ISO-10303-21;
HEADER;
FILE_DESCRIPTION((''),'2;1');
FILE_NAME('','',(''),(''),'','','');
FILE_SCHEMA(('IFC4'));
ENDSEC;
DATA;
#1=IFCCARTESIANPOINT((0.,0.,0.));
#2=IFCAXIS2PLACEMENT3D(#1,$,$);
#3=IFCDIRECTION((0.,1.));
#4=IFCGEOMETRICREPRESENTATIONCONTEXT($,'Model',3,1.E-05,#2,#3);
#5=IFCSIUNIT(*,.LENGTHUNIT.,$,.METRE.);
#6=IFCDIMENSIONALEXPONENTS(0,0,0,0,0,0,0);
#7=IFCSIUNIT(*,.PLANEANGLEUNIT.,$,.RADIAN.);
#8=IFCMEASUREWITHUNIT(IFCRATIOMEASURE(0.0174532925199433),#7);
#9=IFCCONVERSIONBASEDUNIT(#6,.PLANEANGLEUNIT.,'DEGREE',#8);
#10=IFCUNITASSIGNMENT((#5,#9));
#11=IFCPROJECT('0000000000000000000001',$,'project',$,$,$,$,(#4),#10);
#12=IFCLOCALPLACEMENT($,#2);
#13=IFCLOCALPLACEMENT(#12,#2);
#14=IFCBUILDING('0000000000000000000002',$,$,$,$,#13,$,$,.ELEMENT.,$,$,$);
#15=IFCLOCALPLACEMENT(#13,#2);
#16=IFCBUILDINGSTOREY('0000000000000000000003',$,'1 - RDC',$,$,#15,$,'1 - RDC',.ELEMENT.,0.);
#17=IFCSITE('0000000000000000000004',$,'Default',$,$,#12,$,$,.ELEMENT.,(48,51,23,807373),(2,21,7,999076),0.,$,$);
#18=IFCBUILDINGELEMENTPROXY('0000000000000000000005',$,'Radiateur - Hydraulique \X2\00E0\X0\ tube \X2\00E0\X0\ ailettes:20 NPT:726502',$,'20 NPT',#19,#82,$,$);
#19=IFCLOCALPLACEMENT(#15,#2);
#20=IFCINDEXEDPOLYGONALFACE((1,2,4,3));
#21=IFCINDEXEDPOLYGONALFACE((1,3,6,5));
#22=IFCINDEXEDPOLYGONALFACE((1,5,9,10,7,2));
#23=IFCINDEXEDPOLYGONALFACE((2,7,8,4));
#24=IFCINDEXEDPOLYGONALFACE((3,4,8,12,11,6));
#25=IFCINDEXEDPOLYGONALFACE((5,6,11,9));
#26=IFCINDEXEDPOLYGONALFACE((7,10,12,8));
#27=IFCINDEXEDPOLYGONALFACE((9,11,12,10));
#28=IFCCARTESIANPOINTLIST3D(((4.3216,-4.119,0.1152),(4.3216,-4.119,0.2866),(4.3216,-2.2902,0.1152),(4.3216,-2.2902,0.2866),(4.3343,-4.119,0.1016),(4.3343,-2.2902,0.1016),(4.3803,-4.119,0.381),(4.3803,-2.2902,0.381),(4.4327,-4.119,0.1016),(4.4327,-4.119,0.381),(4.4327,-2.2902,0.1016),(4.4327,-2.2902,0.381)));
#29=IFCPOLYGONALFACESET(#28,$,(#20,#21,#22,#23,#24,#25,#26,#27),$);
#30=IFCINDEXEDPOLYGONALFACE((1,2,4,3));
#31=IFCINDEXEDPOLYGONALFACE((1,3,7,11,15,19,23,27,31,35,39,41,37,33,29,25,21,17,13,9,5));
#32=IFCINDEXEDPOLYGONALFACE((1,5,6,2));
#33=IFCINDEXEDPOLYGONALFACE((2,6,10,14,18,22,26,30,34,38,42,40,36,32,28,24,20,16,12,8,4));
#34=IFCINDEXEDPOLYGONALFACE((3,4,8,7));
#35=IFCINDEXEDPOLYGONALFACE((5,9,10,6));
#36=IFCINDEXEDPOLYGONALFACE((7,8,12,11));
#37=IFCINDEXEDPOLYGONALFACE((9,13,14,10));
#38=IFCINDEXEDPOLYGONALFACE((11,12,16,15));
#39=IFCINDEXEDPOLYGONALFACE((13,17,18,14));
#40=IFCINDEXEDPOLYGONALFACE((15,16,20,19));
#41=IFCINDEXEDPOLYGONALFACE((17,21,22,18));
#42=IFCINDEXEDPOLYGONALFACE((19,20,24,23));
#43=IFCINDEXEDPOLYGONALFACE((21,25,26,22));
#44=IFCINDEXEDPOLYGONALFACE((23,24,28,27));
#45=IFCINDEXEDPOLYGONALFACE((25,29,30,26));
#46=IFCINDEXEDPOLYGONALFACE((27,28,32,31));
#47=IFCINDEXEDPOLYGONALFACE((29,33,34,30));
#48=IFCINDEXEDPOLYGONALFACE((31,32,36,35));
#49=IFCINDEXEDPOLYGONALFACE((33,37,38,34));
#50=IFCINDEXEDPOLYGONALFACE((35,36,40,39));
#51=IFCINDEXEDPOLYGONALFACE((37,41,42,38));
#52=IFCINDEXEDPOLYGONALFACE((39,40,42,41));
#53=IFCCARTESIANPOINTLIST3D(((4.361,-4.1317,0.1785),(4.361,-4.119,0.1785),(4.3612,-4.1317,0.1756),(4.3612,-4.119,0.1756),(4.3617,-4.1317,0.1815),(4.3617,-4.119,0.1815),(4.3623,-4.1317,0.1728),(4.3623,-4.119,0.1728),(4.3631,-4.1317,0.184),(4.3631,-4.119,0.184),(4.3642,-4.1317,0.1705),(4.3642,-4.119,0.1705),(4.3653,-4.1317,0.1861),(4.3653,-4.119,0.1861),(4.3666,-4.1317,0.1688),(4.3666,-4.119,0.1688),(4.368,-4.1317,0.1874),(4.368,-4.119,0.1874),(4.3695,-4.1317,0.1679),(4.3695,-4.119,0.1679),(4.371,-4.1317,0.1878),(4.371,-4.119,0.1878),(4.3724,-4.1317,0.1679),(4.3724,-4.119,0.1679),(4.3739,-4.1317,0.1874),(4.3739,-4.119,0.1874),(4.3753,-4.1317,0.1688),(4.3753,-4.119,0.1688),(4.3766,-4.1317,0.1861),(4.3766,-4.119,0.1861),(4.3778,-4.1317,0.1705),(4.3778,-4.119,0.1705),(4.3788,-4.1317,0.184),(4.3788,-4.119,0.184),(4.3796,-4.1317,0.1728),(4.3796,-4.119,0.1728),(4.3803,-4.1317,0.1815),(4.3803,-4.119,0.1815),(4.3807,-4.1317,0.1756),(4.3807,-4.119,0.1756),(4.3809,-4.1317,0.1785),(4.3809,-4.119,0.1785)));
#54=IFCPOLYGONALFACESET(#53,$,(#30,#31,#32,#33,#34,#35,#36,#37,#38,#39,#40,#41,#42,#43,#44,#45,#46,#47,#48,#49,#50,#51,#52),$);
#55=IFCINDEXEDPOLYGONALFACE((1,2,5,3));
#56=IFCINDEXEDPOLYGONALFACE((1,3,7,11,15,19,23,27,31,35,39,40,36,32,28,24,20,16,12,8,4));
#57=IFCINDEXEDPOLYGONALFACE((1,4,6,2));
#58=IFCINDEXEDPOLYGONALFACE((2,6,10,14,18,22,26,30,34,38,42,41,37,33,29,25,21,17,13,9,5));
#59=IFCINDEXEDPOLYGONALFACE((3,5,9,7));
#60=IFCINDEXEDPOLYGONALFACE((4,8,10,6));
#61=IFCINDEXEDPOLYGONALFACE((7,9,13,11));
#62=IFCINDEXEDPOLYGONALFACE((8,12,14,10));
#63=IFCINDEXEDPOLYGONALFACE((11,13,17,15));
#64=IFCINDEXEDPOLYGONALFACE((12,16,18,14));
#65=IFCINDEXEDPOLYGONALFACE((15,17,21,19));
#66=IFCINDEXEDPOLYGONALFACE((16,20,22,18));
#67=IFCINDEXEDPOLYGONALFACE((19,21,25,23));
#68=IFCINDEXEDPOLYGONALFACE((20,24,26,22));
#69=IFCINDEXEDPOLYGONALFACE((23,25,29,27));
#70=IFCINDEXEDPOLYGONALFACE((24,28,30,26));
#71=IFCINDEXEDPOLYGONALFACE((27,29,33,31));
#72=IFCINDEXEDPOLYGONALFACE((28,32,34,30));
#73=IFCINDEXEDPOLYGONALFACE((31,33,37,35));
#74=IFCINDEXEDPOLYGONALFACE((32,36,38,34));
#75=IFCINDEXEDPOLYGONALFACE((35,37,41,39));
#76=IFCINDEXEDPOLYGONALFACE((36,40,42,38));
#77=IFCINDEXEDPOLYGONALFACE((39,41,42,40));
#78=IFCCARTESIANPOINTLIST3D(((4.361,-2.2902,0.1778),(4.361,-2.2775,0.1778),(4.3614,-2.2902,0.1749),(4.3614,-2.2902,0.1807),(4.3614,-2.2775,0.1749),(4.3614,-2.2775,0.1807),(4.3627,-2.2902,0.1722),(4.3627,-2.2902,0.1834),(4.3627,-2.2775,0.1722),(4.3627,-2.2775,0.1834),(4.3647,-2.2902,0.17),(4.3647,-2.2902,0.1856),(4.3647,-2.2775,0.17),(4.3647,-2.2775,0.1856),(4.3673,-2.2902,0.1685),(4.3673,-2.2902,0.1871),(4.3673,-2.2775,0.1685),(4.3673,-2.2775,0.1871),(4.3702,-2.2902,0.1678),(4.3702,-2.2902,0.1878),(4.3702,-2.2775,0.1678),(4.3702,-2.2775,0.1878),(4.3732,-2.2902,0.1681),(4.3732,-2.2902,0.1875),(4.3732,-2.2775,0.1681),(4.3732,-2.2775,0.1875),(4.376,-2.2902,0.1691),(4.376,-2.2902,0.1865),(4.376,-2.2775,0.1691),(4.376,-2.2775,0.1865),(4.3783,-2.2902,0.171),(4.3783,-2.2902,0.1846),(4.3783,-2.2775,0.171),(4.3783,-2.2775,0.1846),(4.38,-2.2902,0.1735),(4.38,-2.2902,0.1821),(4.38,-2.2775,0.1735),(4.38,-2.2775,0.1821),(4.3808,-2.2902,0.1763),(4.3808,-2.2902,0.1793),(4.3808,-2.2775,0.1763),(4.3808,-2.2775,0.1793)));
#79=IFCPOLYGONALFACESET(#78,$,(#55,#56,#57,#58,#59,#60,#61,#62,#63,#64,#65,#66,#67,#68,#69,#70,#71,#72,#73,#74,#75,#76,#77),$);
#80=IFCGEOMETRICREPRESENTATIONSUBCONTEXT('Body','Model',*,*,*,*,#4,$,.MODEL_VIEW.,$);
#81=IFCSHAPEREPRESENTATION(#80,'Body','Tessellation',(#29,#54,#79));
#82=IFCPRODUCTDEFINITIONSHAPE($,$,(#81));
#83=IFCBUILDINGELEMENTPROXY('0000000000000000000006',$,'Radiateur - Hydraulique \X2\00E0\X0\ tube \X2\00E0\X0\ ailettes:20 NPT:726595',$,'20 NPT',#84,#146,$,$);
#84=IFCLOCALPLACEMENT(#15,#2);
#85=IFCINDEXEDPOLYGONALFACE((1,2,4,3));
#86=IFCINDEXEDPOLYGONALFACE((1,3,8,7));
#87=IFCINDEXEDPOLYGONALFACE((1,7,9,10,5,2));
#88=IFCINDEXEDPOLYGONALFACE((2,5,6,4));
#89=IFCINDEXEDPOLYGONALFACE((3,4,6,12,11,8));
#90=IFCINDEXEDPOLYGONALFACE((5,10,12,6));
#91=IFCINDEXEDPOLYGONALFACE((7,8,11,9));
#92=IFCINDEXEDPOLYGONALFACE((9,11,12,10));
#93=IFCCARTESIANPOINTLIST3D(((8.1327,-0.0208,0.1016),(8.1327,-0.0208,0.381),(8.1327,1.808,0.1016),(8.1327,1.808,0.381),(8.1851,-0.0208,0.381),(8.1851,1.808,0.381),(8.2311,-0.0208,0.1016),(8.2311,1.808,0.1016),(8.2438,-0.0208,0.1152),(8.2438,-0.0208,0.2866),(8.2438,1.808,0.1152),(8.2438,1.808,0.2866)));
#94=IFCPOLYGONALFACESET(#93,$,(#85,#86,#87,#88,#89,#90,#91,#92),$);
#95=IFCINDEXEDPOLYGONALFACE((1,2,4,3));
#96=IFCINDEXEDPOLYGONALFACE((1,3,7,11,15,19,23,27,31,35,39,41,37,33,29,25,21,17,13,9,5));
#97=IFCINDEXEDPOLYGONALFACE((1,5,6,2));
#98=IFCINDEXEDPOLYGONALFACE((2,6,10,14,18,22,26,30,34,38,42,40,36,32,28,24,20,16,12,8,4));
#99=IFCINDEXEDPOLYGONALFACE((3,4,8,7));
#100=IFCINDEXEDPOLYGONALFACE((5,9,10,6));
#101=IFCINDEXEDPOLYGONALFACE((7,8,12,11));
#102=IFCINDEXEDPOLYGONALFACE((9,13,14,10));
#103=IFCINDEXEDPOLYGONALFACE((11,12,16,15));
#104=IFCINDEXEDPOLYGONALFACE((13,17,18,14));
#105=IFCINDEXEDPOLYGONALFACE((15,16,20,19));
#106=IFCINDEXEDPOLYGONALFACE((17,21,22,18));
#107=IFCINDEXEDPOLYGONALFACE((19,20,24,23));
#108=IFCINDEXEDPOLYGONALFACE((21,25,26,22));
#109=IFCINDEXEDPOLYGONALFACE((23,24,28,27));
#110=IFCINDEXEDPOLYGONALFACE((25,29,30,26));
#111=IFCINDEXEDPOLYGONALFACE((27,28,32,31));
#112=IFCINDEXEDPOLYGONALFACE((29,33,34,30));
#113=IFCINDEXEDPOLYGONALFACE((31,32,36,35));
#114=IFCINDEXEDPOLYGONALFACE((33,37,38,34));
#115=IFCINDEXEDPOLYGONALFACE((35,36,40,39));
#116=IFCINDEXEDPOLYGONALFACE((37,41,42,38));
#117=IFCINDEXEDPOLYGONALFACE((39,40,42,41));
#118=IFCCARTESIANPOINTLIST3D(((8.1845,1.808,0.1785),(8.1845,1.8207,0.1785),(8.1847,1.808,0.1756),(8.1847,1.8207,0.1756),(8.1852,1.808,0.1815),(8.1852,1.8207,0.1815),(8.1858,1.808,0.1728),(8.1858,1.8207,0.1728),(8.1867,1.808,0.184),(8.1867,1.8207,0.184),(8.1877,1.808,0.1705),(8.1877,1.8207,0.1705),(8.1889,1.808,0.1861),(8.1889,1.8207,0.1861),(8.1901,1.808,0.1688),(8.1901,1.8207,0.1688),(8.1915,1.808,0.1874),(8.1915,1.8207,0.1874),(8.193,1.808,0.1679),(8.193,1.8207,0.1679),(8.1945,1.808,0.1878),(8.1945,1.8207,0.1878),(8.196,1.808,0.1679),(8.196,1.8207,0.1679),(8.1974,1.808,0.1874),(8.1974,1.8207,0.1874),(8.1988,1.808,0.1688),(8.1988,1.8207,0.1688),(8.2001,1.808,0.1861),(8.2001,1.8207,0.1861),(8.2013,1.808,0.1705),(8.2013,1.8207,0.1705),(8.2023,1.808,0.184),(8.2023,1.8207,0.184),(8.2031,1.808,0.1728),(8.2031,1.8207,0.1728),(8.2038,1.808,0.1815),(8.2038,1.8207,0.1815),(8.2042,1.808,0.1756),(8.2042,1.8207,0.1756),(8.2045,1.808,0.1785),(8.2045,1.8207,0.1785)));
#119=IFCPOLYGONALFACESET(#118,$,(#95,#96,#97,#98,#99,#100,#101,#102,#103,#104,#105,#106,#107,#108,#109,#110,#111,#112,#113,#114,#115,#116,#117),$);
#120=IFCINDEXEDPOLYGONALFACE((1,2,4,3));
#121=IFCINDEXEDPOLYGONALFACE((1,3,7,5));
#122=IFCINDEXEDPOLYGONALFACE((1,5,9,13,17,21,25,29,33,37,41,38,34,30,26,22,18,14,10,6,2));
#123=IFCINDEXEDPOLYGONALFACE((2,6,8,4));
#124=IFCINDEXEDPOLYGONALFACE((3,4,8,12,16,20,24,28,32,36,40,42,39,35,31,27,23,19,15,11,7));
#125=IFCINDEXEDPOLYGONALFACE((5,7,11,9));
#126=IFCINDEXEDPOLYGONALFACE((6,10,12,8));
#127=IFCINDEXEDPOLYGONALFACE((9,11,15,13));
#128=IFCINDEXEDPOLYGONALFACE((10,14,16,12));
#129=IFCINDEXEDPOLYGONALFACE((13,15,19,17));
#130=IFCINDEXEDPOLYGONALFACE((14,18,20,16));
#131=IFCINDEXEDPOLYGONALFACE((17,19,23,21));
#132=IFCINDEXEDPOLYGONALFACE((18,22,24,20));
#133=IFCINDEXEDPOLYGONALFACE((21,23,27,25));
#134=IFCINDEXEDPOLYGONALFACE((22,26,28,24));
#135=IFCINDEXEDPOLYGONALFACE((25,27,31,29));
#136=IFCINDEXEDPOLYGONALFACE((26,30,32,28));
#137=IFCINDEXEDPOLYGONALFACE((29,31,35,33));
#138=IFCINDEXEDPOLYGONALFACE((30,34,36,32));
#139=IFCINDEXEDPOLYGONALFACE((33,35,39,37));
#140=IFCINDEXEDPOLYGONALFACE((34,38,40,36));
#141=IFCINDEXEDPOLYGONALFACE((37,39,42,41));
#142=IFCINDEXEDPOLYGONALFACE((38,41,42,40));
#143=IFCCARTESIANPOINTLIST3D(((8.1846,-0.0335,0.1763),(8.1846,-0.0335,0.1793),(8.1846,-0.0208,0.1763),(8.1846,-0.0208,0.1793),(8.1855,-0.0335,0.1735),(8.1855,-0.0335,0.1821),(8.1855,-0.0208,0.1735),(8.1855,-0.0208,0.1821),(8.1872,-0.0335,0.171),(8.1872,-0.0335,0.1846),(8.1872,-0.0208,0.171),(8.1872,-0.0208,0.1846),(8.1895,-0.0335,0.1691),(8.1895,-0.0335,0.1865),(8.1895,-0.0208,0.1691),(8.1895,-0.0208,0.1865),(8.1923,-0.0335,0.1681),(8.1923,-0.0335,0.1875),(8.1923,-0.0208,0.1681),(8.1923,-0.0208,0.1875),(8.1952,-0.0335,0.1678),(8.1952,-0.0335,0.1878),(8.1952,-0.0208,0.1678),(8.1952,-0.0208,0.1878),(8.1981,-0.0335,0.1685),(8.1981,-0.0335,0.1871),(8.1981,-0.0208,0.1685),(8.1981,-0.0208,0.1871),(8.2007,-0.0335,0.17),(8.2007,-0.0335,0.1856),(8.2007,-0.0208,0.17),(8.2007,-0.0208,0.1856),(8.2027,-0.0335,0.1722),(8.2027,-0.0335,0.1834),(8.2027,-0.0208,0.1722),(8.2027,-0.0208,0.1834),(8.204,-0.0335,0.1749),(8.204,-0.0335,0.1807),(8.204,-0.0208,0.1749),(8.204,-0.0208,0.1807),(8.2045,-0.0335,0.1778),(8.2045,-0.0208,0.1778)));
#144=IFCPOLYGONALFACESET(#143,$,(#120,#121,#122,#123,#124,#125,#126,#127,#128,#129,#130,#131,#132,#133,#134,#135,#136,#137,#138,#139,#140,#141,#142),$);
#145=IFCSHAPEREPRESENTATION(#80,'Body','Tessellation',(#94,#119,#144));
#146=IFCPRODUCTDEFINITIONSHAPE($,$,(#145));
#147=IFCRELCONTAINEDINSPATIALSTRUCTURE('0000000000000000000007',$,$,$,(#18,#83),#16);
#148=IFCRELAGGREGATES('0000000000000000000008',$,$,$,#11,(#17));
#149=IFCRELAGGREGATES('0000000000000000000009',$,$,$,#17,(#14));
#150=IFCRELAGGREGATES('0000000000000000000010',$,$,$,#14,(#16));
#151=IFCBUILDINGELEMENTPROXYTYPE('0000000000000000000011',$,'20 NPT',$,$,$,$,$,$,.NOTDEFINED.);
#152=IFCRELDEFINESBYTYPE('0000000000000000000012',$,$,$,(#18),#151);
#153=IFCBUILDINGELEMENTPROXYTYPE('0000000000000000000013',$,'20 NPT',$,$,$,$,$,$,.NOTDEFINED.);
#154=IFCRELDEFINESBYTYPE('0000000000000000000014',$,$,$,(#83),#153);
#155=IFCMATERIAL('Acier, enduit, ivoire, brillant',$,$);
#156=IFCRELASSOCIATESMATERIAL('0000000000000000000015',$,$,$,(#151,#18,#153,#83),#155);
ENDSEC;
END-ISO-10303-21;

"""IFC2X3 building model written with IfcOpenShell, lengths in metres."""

from ifc_helpers import new_model, entity, si_unit, converted_unit, direction, frame, frame_2d, origin, place, context, subcontext, project, spatial, polyline, circle, outline, extrude, source, transform, mapped, material, type_object, type_shapes, element, save


model = new_model("IFC2X3")

# Units and contexts
model_context = context("Model", 3, precision=1e-05, world=origin(), true_north=direction((0.0, 1.0)))
body_context = subcontext(model_context, "Body", "Model", "MODEL_VIEW")
ifc_project = project(units=[si_unit("LENGTHUNIT", "METRE"), converted_unit("PLANEANGLEUNIT", "DEGREE", entity("IfcRatioMeasure", 0.0174532925199433), si_unit("PLANEANGLEUNIT", "RADIAN"), dimensions=[0, 0, 0, 0, 0, 0, 0])], contexts=[model_context])

# Site, building, storey
site_placement = place(None, origin())
site = spatial("IfcSite", under=ifc_project, at=site_placement, Name="Default", CompositionType="ELEMENT", RefLatitude=(48, 51, 23, 807373), RefLongitude=(2, 21, 7, 999076), RefElevation=0.0)
building_placement = place(site_placement, origin())
building = spatial("IfcBuilding", under=site, at=building_placement, CompositionType="ELEMENT")
storey_placement = place(building_placement, origin())
storey = spatial("IfcBuildingStorey", under=building, at=storey_placement, Name="1 - RDC", LongName="1 - RDC", CompositionType="ELEMENT", Elevation=0.0)

# Building element proxies
ifc_material = material(Name="Acier, enduit, ivoire, brillant")
building_element_proxy_type_1 = type_object("IfcBuildingElementProxyType", Name="20 NPT", PredefinedType="NOTDEFINED", material=ifc_material)
shared_shape_1 = source(origin(), body_context, "Body", "SweptSolid", [
    extrude(outline(polyline([(-0.0674, -0.1127), (-0.0488, -0.1127), (0.0764, 0.0044), (0.1052, 0.1118), (0.0694, 0.15), (-0.1347, -0.0408), (-0.0674, -0.1127)])), frame((-0.9144, 0.1322, 0.2278), z_axis=(1.0, 0.0, 0.0), x_axis=(0.0, 0.683102, 0.730323)), (0.0, 0.0, 1.0), 1.8288),
    extrude(circle(Radius=0.01, at=frame_2d((0.0, 0.0), x_axis=(1.0, 0.0))), frame((-0.9271, 0.1318, 0.1778), z_axis=(1.0, 0.0, 0.0), x_axis=(0.0, 0.0, 1.0)), (0.0, 0.0, 1.0), 0.0127),
    extrude(circle(Radius=0.01, at=frame_2d((0.0, 0.0), x_axis=(1.0, 0.0))), frame((0.9144, 0.1318, 0.1778), z_axis=(1.0, 0.0, 0.0), x_axis=(0.0, 1.0, 0.0)), (0.0, 0.0, 1.0), 0.0127),
])
type_shapes(building_element_proxy_type_1, [shared_shape_1])
proxy_1_placement = place(storey_placement, frame((4.5027, -3.2046, 0.0), z_axis=(0.0, 0.0, 1.0), x_axis=(0.0, 1.0, 0.0)))
element("IfcBuildingElementProxy", 1, at=proxy_1_placement, inside=storey, type_object=building_element_proxy_type_1, material=ifc_material, Name="Radiateur - Hydraulique à tube à ailettes:20 NPT:726502", ObjectType="20 NPT", context=body_context, shape_type="MappedRepresentation", body=[
    mapped(shared_shape_1, transform((0.0, 0.0, 0.0), scale=1.0)),
])
building_element_proxy_type_2 = type_object("IfcBuildingElementProxyType", Name="20 NPT", PredefinedType="NOTDEFINED", material=ifc_material)
shared_shape_2 = source(origin(), body_context, "Body", "SweptSolid", [
    extrude(outline(polyline([(-0.0674, -0.1127), (-0.0488, -0.1127), (0.0764, 0.0044), (0.1052, 0.1118), (0.0694, 0.15), (-0.1347, -0.0408), (-0.0674, -0.1127)])), frame((-0.9144, 0.1322, 0.2278), z_axis=(1.0, 0.0, 0.0), x_axis=(0.0, 0.683102, 0.730323)), (0.0, 0.0, 1.0), 1.8288),
    extrude(circle(Radius=0.01, at=frame_2d((0.0, 0.0), x_axis=(1.0, 0.0))), frame((-0.9271, 0.1318, 0.1778), z_axis=(1.0, 0.0, 0.0), x_axis=(0.0, 0.0, 1.0)), (0.0, 0.0, 1.0), 0.0127),
    extrude(circle(Radius=0.01, at=frame_2d((0.0, 0.0), x_axis=(1.0, 0.0))), frame((0.9144, 0.1318, 0.1778), z_axis=(1.0, 0.0, 0.0), x_axis=(0.0, 1.0, 0.0)), (0.0, 0.0, 1.0), 0.0127),
])
type_shapes(building_element_proxy_type_2, [shared_shape_2])
proxy_2_placement = place(storey_placement, frame((8.0627, 0.8936, 0.0), z_axis=(0.0, 0.0, 1.0), x_axis=(0.0, -1.0, 0.0)))
element("IfcBuildingElementProxy", 2, at=proxy_2_placement, inside=storey, type_object=building_element_proxy_type_2, material=ifc_material, Name="Radiateur - Hydraulique à tube à ailettes:20 NPT:726595", ObjectType="20 NPT", context=body_context, shape_type="MappedRepresentation", body=[
    mapped(shared_shape_2, transform((0.0, 0.0, 0.0), scale=1.0)),
])

save(model, "model.ifc")
